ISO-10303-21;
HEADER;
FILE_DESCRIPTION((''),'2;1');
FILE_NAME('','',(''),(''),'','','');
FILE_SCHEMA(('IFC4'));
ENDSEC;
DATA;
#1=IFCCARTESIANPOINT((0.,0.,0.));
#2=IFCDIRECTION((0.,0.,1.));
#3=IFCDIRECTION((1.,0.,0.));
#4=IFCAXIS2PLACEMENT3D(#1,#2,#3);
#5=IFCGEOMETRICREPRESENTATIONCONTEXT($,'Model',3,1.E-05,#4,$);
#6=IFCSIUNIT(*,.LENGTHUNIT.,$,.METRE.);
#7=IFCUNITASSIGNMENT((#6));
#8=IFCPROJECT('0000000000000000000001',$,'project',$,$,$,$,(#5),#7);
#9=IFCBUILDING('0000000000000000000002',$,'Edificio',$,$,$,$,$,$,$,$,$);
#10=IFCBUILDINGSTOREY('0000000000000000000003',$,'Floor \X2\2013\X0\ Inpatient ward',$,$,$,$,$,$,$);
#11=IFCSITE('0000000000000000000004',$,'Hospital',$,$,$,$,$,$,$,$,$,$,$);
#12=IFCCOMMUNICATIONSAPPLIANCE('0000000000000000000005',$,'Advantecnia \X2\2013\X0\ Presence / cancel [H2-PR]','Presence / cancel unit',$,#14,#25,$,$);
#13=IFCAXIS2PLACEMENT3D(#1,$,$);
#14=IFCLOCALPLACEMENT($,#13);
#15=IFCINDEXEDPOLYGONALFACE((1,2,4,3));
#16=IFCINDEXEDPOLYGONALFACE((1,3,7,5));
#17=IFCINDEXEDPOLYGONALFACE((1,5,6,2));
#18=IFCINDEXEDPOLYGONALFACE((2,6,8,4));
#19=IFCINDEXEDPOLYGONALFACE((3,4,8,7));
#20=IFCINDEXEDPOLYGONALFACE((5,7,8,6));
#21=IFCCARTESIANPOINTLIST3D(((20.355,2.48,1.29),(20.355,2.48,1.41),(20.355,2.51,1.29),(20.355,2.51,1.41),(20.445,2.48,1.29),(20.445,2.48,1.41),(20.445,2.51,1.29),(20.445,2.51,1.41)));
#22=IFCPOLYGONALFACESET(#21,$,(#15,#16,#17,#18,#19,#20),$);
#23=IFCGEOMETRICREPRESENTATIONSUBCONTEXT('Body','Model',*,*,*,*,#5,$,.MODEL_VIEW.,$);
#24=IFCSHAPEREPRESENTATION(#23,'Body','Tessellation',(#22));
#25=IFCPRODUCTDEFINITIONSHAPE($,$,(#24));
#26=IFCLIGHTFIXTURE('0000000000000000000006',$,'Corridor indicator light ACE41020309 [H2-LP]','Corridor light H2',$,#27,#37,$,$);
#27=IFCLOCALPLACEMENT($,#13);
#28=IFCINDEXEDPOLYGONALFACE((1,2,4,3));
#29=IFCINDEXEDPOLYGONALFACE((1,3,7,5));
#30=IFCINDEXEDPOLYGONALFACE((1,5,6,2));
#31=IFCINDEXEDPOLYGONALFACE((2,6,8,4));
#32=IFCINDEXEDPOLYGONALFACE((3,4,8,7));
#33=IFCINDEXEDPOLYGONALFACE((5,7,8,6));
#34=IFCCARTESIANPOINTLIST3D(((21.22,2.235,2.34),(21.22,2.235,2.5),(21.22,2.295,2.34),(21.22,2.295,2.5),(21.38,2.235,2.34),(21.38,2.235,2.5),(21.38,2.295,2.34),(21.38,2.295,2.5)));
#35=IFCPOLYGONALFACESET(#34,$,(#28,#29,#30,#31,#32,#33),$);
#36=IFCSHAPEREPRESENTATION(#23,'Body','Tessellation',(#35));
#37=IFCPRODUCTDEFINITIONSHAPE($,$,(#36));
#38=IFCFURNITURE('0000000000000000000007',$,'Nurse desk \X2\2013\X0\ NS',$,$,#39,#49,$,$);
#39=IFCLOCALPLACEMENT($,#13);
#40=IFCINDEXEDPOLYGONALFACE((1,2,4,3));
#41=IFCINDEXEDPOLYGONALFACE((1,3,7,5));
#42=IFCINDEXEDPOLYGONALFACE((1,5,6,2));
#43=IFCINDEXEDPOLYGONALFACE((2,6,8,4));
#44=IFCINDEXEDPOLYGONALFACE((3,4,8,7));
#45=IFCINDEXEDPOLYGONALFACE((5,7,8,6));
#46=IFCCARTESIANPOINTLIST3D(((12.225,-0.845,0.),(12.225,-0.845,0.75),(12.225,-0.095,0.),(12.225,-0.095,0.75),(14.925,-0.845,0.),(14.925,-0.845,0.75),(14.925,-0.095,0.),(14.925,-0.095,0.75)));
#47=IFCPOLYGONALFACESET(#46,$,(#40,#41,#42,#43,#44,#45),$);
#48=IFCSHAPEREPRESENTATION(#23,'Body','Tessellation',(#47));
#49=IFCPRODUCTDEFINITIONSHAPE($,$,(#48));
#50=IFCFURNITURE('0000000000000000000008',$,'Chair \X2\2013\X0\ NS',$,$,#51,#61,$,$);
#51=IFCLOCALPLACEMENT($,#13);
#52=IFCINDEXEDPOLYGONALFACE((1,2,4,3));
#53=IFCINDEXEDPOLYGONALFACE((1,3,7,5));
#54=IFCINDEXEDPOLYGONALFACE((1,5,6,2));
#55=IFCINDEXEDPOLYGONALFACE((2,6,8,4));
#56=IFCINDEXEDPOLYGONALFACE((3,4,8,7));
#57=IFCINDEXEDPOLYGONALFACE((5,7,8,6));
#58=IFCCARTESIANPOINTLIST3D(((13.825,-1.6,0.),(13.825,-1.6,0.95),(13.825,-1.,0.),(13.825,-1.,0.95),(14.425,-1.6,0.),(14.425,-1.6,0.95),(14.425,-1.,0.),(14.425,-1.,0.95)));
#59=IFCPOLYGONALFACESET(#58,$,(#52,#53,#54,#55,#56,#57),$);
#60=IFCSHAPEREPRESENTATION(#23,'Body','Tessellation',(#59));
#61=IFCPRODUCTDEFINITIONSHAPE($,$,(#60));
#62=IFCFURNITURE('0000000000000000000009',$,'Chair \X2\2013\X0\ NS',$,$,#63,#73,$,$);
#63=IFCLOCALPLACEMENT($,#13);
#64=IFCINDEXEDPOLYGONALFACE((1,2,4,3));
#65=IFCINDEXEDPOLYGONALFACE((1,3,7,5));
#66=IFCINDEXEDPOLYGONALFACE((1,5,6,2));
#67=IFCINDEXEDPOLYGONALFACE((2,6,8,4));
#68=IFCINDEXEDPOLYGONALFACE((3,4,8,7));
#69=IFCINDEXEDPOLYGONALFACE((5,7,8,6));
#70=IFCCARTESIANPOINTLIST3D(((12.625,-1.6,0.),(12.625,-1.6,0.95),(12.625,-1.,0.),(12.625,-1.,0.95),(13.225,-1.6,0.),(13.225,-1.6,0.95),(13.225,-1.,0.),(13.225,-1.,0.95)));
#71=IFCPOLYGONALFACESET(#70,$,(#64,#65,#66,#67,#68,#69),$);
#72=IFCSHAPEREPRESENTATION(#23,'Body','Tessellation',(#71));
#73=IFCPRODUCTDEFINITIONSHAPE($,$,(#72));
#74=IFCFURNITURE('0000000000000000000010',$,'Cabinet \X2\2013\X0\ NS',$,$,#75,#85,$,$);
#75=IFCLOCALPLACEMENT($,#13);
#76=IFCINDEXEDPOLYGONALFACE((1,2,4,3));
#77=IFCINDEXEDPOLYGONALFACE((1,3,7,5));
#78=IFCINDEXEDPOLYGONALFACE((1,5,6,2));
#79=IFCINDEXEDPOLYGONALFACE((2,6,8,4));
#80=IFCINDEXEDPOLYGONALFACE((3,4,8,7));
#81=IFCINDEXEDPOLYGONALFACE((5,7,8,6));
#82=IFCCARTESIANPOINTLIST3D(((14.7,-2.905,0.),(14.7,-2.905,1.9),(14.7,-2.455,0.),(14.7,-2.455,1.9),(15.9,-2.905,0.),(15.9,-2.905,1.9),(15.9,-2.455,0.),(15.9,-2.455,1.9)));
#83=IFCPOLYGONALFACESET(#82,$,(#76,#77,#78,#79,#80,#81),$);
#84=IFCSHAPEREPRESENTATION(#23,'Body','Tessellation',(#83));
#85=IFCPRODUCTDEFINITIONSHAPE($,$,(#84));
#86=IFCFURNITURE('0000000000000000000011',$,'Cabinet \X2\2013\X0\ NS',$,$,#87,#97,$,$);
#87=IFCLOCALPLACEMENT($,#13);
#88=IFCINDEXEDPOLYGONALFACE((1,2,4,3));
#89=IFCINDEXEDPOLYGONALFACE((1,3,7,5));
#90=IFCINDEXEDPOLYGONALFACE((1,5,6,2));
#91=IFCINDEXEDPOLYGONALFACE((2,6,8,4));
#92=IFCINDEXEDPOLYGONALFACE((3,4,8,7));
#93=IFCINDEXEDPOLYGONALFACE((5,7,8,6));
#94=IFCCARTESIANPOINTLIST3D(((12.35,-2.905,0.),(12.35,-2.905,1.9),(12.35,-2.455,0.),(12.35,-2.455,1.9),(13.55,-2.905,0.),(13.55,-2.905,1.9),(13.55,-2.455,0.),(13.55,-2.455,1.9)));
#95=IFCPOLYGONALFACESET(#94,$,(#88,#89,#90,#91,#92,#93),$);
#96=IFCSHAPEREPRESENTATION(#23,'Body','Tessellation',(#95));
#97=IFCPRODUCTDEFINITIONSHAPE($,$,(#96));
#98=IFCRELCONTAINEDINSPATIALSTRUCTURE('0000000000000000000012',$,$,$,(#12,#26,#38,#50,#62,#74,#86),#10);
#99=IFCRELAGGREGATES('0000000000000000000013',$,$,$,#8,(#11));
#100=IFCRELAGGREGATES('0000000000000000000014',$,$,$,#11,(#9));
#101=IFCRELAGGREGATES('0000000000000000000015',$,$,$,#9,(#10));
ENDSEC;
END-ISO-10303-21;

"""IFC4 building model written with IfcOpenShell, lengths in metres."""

from ifc_helpers import new_model, si_unit, frame, origin_with_axes, context, subcontext, project, spatial, line, indexed_curve, outline, extrude, element, save


model = new_model("IFC4")

# Units and contexts
model_context = context("Model", 3, precision=1e-05, world=origin_with_axes())
body_context = subcontext(model_context, "Body", "Model", "MODEL_VIEW")
ifc_project = project(units=[si_unit("LENGTHUNIT", "METRE")], contexts=[model_context])

# Site, building, storey
site = spatial("IfcSite", under=ifc_project, Name="Hospital")
building = spatial("IfcBuilding", under=site, Name="Edificio")
storey = spatial("IfcBuildingStorey", under=building, Name="Floor – Inpatient ward")

# Communications appliance
element("IfcCommunicationsAppliance", 1, inside=storey, Name="Advantecnia – Presence / cancel [H2-PR]", Description="Presence / cancel unit", context=body_context, shape_type="SweptSolid", body=[
    extrude(outline(indexed_curve([(0.0, 0.0), (0.09, 0.0), (0.09, 0.03), (0.0, 0.03)], segments=[line(1, 2, 3, 4, 1)])), frame((20.355, 2.48, 1.29), z_axis=(0.0, 0.0, 1.0), x_axis=(1.0, 0.0, 0.0)), (0.0, 0.0, 1.0), 0.12),
])

# Light fixture
element("IfcLightFixture", 2, inside=storey, Name="Corridor indicator light ACE41020309 [H2-LP]", Description="Corridor light H2", context=body_context, shape_type="SweptSolid", body=[
    extrude(outline(indexed_curve([(0.0, 0.0), (0.16, 0.0), (0.16, 0.06), (0.0, 0.06)], segments=[line(1, 2, 3, 4, 1)])), frame((21.22, 2.235, 2.34), z_axis=(0.0, 0.0, 1.0), x_axis=(1.0, 0.0, 0.0)), (0.0, 0.0, 1.0), 0.16),
])

# Furniture
element("IfcFurniture", 3, inside=storey, Name="Nurse desk – NS", context=body_context, shape_type="SweptSolid", body=[
    extrude(outline(indexed_curve([(0.0, 0.0), (2.7, 0.0), (2.7, 0.75), (0.0, 0.75)], segments=[line(1, 2, 3, 4, 1)])), frame((12.225, -0.845, 0.0), z_axis=(0.0, 0.0, 1.0), x_axis=(1.0, 0.0, 0.0)), (0.0, 0.0, 1.0), 0.75),
])
element("IfcFurniture", 4, inside=storey, Name="Chair – NS", context=body_context, shape_type="SweptSolid", body=[
    extrude(outline(indexed_curve([(0.0, 0.0), (0.6, 0.0), (0.6, 0.6), (0.0, 0.6)], segments=[line(1, 2, 3, 4, 1)])), frame((13.825, -1.6, 0.0), z_axis=(0.0, 0.0, 1.0), x_axis=(1.0, 0.0, 0.0)), (0.0, 0.0, 1.0), 0.95),
])
element("IfcFurniture", 5, inside=storey, Name="Chair – NS", context=body_context, shape_type="SweptSolid", body=[
    extrude(outline(indexed_curve([(0.0, 0.0), (0.6, 0.0), (0.6, 0.6), (0.0, 0.6)], segments=[line(1, 2, 3, 4, 1)])), frame((12.625, -1.6, 0.0), z_axis=(0.0, 0.0, 1.0), x_axis=(1.0, 0.0, 0.0)), (0.0, 0.0, 1.0), 0.95),
])
element("IfcFurniture", 6, inside=storey, Name="Cabinet – NS", context=body_context, shape_type="SweptSolid", body=[
    extrude(outline(indexed_curve([(0.0, 0.0), (1.2, 0.0), (1.2, 0.45), (0.0, 0.45)], segments=[line(1, 2, 3, 4, 1)])), frame((14.7, -2.905, 0.0), z_axis=(0.0, 0.0, 1.0), x_axis=(1.0, 0.0, 0.0)), (0.0, 0.0, 1.0), 1.9),
])
element("IfcFurniture", 7, inside=storey, Name="Cabinet – NS", context=body_context, shape_type="SweptSolid", body=[
    extrude(outline(indexed_curve([(0.0, 0.0), (1.2, 0.0), (1.2, 0.45), (0.0, 0.45)], segments=[line(1, 2, 3, 4, 1)])), frame((12.35, -2.905, 0.0), z_axis=(0.0, 0.0, 1.0), x_axis=(1.0, 0.0, 0.0)), (0.0, 0.0, 1.0), 1.9),
])

save(model, "model.ifc")
